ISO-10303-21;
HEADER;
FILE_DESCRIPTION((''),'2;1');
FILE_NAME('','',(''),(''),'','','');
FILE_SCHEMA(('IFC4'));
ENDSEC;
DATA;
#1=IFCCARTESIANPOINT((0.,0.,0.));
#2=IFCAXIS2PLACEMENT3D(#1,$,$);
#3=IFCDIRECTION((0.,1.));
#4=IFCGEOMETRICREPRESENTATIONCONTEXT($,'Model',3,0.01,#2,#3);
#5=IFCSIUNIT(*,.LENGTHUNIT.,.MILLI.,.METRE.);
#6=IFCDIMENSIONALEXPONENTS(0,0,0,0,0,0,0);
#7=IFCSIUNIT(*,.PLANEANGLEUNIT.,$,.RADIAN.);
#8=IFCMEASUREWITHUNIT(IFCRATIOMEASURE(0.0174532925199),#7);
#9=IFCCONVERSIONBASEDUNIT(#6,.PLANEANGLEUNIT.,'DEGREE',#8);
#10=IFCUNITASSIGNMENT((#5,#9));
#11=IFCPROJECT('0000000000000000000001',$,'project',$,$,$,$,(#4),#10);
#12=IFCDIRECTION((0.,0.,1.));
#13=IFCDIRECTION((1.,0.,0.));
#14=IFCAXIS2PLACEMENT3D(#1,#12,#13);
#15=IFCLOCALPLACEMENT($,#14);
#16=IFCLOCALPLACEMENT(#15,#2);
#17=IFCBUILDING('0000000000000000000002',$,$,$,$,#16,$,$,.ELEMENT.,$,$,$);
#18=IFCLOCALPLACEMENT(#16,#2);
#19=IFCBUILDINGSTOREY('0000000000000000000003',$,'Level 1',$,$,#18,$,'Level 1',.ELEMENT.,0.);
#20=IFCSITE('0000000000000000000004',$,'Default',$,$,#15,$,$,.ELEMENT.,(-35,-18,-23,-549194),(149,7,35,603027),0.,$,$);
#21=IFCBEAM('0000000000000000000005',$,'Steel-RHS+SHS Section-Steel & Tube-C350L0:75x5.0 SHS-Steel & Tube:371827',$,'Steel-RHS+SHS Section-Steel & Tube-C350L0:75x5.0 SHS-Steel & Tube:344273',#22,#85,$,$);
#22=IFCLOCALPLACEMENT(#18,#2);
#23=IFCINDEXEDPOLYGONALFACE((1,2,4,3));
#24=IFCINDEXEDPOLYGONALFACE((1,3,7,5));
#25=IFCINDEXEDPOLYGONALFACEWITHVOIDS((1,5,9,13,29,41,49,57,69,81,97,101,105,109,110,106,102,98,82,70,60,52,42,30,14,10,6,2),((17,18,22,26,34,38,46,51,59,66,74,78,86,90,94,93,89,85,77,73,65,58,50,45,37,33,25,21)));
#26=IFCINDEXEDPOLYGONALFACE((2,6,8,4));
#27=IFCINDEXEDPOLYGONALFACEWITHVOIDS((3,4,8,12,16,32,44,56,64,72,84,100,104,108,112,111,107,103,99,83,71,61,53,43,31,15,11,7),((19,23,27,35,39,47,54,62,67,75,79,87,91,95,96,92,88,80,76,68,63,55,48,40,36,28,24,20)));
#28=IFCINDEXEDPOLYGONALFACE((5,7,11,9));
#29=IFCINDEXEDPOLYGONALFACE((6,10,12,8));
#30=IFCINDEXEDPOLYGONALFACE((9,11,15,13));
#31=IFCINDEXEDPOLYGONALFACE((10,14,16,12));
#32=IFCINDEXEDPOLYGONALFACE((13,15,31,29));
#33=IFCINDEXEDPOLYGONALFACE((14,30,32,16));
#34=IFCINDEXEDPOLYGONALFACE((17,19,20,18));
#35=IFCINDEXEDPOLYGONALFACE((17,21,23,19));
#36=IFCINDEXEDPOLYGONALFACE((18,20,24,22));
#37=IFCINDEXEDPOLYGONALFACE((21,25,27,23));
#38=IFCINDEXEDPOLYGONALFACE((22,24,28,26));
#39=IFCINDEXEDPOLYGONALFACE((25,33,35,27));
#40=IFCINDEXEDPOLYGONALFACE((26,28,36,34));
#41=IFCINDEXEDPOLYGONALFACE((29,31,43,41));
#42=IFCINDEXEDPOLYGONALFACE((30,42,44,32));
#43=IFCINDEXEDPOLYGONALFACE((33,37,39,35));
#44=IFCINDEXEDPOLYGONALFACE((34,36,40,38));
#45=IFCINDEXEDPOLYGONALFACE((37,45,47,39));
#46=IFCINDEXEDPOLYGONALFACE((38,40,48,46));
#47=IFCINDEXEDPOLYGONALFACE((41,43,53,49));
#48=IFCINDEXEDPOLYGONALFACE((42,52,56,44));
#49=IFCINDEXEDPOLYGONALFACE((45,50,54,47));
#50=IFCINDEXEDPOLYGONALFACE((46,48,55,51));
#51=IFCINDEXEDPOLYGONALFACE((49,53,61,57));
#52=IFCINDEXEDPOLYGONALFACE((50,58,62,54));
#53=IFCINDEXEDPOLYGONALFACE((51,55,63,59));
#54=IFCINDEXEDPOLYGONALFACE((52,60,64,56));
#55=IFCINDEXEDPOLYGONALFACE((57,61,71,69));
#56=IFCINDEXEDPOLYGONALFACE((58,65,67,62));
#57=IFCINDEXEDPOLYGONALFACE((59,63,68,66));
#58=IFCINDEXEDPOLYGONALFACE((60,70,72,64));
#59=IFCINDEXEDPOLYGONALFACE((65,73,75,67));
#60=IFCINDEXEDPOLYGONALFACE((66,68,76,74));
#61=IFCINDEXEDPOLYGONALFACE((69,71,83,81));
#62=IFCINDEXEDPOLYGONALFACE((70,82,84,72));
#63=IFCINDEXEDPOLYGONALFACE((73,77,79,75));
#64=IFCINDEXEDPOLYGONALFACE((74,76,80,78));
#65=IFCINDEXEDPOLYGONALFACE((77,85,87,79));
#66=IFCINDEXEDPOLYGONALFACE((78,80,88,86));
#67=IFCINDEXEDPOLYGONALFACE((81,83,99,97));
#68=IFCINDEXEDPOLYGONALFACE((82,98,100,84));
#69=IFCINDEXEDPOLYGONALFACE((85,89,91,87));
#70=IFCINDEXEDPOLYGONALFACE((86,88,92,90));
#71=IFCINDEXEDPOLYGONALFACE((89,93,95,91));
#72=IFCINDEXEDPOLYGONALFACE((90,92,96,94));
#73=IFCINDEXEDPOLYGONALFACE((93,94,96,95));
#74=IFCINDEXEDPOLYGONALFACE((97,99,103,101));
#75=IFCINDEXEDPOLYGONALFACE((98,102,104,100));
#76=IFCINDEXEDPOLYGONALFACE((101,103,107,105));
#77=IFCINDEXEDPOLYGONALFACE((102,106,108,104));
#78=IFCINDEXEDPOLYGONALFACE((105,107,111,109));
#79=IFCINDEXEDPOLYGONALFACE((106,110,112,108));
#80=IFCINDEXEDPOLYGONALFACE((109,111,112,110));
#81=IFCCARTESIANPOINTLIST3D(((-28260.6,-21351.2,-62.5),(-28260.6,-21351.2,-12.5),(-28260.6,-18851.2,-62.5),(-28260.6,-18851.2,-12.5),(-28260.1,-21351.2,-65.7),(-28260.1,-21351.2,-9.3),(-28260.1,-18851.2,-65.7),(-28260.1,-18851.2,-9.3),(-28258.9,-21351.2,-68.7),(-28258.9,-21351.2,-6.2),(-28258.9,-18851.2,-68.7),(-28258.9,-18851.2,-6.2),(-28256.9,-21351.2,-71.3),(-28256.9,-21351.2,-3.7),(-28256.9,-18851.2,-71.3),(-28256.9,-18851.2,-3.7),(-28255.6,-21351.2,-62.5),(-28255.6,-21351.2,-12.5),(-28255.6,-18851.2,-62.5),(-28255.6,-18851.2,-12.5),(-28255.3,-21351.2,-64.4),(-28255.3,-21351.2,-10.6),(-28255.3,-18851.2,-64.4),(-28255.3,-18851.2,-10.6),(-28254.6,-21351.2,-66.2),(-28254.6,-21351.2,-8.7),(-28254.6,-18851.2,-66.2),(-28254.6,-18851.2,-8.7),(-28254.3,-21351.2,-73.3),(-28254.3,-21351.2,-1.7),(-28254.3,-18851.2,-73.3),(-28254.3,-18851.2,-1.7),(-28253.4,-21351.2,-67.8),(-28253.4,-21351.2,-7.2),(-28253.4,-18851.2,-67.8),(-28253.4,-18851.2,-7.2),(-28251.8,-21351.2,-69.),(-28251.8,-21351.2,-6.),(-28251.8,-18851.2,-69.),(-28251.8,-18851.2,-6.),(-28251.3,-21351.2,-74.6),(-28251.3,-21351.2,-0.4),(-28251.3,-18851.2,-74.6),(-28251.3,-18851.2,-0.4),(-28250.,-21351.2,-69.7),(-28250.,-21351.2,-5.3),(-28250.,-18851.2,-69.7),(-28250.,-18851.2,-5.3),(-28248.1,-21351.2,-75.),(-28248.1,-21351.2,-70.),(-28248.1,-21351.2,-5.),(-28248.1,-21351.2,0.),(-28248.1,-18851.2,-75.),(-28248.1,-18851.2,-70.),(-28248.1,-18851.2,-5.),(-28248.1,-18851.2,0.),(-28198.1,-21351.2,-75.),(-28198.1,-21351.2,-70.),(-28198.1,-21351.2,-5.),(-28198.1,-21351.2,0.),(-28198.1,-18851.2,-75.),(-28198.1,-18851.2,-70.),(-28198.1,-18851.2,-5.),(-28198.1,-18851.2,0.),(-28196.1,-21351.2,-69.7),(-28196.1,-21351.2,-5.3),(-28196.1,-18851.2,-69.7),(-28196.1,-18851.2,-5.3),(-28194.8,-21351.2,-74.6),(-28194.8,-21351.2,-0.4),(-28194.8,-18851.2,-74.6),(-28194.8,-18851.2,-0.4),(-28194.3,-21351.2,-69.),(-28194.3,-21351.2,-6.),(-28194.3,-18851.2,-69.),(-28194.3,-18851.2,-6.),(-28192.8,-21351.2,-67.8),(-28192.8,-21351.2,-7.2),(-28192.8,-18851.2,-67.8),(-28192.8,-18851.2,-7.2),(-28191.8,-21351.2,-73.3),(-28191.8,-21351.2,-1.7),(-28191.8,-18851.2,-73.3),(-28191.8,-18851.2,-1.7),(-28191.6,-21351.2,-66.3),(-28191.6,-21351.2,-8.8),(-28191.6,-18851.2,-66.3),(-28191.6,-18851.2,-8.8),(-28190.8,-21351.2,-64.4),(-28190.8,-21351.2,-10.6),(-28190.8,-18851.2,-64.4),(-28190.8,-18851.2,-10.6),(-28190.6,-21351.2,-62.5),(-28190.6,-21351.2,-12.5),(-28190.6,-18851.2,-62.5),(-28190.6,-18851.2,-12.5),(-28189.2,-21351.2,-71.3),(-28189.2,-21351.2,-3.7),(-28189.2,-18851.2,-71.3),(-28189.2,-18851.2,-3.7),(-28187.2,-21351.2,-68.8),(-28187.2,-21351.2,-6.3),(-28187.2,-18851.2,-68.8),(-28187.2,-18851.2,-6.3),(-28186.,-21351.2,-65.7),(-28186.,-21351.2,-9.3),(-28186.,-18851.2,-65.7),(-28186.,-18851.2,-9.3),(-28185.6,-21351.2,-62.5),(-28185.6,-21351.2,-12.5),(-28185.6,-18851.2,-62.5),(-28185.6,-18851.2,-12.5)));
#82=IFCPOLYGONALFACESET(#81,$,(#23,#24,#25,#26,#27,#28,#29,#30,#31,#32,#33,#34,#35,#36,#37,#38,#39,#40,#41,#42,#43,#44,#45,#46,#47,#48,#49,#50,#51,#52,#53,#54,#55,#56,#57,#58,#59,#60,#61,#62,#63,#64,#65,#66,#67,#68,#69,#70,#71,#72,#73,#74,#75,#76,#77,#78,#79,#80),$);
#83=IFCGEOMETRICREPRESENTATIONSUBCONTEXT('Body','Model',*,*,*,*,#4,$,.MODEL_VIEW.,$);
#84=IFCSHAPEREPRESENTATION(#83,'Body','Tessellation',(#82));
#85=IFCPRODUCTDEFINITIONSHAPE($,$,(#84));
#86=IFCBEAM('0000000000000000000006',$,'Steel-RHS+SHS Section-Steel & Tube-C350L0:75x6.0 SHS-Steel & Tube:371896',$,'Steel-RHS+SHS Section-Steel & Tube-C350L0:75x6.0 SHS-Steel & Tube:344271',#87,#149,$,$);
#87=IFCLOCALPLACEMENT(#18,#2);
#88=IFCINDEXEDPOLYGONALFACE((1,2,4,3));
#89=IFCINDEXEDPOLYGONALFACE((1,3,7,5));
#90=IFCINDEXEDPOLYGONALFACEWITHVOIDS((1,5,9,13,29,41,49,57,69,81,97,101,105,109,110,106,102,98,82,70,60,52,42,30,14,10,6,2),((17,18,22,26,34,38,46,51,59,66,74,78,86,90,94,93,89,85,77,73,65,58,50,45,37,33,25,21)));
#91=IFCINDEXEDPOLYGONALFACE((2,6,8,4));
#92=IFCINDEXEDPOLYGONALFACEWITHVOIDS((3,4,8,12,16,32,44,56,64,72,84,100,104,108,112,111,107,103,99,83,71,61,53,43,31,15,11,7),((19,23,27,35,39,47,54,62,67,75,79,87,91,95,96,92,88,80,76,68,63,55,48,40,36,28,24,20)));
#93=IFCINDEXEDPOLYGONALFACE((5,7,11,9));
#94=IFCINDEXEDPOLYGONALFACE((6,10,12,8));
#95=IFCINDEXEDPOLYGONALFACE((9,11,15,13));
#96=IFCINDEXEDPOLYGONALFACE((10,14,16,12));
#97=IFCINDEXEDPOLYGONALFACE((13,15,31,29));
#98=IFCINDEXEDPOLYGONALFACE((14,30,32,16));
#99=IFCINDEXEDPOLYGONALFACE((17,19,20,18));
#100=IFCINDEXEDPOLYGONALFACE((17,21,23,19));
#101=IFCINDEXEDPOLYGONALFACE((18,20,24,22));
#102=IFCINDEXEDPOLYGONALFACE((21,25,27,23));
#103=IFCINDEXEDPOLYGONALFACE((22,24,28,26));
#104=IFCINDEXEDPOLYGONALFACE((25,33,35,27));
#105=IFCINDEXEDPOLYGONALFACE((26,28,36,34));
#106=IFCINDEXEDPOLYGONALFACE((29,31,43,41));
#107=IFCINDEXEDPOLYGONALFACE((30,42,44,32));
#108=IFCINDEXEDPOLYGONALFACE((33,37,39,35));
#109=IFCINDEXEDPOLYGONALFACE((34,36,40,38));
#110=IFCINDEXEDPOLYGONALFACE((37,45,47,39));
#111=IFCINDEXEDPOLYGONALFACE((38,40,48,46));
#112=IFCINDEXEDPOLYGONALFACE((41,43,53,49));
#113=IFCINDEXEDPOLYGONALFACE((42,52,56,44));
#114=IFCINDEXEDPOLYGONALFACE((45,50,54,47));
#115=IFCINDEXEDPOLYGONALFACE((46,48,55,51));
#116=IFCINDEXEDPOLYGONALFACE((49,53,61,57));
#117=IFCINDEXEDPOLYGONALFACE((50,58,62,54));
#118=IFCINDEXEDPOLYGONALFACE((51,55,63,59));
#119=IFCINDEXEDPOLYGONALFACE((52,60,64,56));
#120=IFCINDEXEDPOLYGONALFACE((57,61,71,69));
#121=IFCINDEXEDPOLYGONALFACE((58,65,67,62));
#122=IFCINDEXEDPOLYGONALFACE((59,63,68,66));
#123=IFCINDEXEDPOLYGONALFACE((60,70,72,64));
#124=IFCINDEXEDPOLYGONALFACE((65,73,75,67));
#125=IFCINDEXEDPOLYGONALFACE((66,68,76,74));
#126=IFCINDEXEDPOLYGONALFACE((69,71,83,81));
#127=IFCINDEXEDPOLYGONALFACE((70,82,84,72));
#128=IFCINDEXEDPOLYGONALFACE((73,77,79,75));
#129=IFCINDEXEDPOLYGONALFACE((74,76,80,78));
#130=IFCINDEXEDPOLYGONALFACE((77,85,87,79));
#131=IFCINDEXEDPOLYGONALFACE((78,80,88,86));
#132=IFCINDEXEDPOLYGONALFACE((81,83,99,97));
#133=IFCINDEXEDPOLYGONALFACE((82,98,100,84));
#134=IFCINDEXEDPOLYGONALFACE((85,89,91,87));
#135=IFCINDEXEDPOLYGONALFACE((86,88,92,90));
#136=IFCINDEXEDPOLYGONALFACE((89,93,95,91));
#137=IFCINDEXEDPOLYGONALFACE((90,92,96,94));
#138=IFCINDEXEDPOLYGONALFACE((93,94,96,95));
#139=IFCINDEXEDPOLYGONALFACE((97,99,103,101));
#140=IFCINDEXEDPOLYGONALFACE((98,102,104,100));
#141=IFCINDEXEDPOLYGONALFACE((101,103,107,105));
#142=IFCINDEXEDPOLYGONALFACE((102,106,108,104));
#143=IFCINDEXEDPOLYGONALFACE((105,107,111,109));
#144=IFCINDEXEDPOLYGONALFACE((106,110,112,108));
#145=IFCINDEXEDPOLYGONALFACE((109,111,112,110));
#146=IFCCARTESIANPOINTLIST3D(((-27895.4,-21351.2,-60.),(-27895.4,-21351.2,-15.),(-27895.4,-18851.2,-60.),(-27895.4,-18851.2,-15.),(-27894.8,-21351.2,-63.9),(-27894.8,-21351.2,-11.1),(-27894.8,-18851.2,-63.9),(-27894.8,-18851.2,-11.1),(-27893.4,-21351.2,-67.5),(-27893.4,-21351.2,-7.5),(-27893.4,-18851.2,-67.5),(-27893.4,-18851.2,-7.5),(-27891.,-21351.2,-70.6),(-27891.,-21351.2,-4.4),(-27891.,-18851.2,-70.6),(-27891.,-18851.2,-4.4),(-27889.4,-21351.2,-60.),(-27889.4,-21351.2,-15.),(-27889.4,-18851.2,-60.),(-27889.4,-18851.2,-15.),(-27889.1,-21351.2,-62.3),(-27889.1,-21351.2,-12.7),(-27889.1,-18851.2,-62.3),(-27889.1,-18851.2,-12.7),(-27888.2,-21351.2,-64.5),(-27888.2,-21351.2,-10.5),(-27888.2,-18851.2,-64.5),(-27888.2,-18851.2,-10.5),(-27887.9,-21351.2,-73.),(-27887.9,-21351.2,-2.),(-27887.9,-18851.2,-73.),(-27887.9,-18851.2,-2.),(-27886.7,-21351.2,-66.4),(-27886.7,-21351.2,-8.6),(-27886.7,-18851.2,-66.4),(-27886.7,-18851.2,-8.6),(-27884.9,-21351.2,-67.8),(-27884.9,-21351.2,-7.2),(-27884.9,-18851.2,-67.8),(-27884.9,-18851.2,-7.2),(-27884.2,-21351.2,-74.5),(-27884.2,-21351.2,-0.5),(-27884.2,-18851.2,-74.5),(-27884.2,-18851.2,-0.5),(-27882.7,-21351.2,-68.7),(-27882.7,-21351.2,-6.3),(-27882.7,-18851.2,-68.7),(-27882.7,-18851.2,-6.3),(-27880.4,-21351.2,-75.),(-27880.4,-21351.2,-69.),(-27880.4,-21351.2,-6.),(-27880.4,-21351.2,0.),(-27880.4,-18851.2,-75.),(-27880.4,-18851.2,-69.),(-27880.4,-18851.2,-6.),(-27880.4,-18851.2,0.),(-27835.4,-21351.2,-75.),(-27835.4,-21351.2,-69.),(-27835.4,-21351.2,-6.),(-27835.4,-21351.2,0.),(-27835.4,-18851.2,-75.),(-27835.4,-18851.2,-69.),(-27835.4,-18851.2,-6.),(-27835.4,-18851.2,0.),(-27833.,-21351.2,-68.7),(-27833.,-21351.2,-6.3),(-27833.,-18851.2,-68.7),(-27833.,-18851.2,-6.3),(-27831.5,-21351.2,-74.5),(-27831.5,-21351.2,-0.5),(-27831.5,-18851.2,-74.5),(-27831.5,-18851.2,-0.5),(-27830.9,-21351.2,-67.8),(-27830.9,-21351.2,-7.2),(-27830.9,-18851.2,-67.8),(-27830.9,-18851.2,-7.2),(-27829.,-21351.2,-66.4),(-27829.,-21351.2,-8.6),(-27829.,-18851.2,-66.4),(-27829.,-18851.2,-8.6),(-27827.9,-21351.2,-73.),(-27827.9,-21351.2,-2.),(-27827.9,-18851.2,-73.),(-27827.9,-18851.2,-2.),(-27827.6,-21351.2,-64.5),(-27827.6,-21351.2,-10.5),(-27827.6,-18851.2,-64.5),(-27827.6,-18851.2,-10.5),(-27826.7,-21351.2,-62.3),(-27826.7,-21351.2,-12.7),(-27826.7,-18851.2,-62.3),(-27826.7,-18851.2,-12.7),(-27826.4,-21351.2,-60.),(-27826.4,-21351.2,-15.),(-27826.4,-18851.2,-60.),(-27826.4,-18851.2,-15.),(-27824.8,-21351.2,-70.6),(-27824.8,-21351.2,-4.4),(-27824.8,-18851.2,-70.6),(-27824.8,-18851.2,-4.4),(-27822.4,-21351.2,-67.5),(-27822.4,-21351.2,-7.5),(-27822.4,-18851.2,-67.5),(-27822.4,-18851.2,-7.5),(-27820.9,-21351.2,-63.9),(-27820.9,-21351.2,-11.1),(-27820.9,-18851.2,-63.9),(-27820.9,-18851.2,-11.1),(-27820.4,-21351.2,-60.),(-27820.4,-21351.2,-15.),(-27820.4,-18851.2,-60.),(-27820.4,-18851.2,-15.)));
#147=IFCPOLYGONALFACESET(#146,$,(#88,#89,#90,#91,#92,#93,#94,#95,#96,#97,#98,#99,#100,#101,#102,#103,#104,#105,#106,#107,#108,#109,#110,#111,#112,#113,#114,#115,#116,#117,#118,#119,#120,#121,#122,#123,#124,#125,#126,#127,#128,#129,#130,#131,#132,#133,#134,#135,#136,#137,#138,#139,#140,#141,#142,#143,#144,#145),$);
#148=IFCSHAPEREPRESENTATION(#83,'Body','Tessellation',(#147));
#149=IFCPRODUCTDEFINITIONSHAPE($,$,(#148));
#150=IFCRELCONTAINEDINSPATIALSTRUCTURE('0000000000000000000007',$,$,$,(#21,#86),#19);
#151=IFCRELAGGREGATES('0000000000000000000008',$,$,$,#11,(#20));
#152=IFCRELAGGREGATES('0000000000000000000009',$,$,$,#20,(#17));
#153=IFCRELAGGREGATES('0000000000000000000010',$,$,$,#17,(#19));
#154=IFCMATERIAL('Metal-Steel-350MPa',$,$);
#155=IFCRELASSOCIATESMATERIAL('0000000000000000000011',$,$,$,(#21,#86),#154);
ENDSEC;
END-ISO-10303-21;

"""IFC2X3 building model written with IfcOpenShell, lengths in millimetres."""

from ifc_helpers import new_model, entity, si_unit, converted_unit, direction, frame, frame_2d, origin, origin_with_axes, place, context, subcontext, project, spatial, polyline, circle_curve, parameter, trimmed, segment, composite_curve, outline, extrude, material, element, save


model = new_model("IFC2X3")

# Units and contexts
model_context = context("Model", 3, precision=0.01, world=origin(), true_north=direction((0.0, 1.0)))
body_context = subcontext(model_context, "Body", "Model", "MODEL_VIEW")
ifc_project = project(units=[si_unit("LENGTHUNIT", "METRE", prefix="MILLI"), converted_unit("PLANEANGLEUNIT", "DEGREE", entity("IfcRatioMeasure", 0.0174532925199), si_unit("PLANEANGLEUNIT", "RADIAN"), dimensions=[0, 0, 0, 0, 0, 0, 0])], contexts=[model_context])

# Site, building, storey
site_placement = place(None, origin_with_axes())
site = spatial("IfcSite", under=ifc_project, at=site_placement, Name="Default", CompositionType="ELEMENT", RefLatitude=(-35, -18, -23, -549194), RefLongitude=(149, 7, 35, 603027), RefElevation=0.0)
building_placement = place(site_placement, origin())
building = spatial("IfcBuilding", under=site, at=building_placement, CompositionType="ELEMENT")
storey_placement = place(building_placement, origin())
storey = spatial("IfcBuildingStorey", under=building, at=storey_placement, Name="Level 1", LongName="Level 1", CompositionType="ELEMENT", Elevation=0.0)

# Beams
ifc_material = material(Name="Metal-Steel-350MPa")
beam_1_placement = place(storey_placement, frame((-28223.1, -18851.2, 0.0), z_axis=(0.0, 0.0, 1.0), x_axis=(0.0, -1.0, 0.0)))
element("IfcBeam", 1, at=beam_1_placement, inside=storey, material=ifc_material, Name="Steel-RHS+SHS Section-Steel & Tube-C350L0:75x5.0 SHS-Steel & Tube:371827", ObjectType="Steel-RHS+SHS Section-Steel & Tube-C350L0:75x5.0 SHS-Steel & Tube:344273", context=body_context, shape_type="SweptSolid", body=[
    extrude(outline(composite_curve([segment(trimmed(circle_curve(frame_2d((-25.0, -25.0), x_axis=(1.0, 0.0)), 12.5), [parameter(180.0)], [parameter(270.0)], True, "PARAMETER"), True, "CONTINUOUS"), segment(polyline([(-25.0, -37.5), (25.0, -37.5)]), True, "CONTINUOUS"), segment(trimmed(circle_curve(frame_2d((25.0, -25.0), x_axis=(1.0, 0.0)), 12.5), [parameter(270.0)], [parameter(0.0)], True, "PARAMETER"), True, "CONTINUOUS"), segment(polyline([(37.5, -25.0), (37.5, 25.0)]), True, "CONTINUOUS"), segment(trimmed(circle_curve(frame_2d((25.0, 25.0), x_axis=(1.0, 0.0)), 12.5), [parameter(0.0)], [parameter(90.0)], True, "PARAMETER"), True, "CONTINUOUS"), segment(polyline([(25.0, 37.5), (-25.0, 37.5)]), True, "CONTINUOUS"), segment(trimmed(circle_curve(frame_2d((-25.0, 25.0), x_axis=(1.0, 0.0)), 12.5), [parameter(90.0)], [parameter(180.0)], True, "PARAMETER"), True, "CONTINUOUS"), segment(polyline([(-37.5, 25.0), (-37.5, -25.0)]), True, "CONTINUOUS")], self_intersect=False), holes=[composite_curve([segment(polyline([(25.0, -32.5), (-25.0, -32.5)]), True, "CONTINUOUS"), segment(trimmed(circle_curve(frame_2d((-25.0, -25.0), x_axis=(1.0, 0.0)), 7.5), [parameter(180.0)], [parameter(270.0)], True, "PARAMETER"), False, "CONTINUOUS"), segment(polyline([(-32.5, -25.0), (-32.5, 25.0)]), True, "CONTINUOUS"), segment(trimmed(circle_curve(frame_2d((-25.0, 25.0), x_axis=(1.0, 0.0)), 7.5), [parameter(90.0)], [parameter(180.0)], True, "PARAMETER"), False, "CONTINUOUS"), segment(polyline([(-25.0, 32.5), (25.0, 32.5)]), True, "CONTINUOUS"), segment(trimmed(circle_curve(frame_2d((25.0, 25.0), x_axis=(1.0, 0.0)), 7.5), [parameter(360.0)], [parameter(90.0)], True, "PARAMETER"), False, "CONTINUOUS"), segment(polyline([(32.5, 25.0), (32.5, -25.0)]), True, "CONTINUOUS"), segment(trimmed(circle_curve(frame_2d((25.0, -25.0), x_axis=(1.0, 0.0)), 7.5), [parameter(270.0)], [parameter(360.0)], True, "PARAMETER"), False, "CONTINUOUS")], self_intersect=False)]), frame((0.0, 0.0, -37.5), z_axis=(1.0, 0.0, 0.0), x_axis=(0.0, -1.0, 0.0)), (0.0, 0.0, 1.0), 2500.0),
])
beam_2_placement = place(storey_placement, frame((-27857.9, -18851.2, 0.0), z_axis=(0.0, 0.0, 1.0), x_axis=(0.0, -1.0, 0.0)))
element("IfcBeam", 2, at=beam_2_placement, inside=storey, material=ifc_material, Name="Steel-RHS+SHS Section-Steel & Tube-C350L0:75x6.0 SHS-Steel & Tube:371896", ObjectType="Steel-RHS+SHS Section-Steel & Tube-C350L0:75x6.0 SHS-Steel & Tube:344271", context=body_context, shape_type="SweptSolid", body=[
    extrude(outline(composite_curve([segment(trimmed(circle_curve(frame_2d((-22.5, -22.5), x_axis=(1.0, 0.0)), 15.0), [parameter(180.0)], [parameter(270.0)], True, "PARAMETER"), True, "CONTINUOUS"), segment(polyline([(-22.5, -37.5), (22.5, -37.5)]), True, "CONTINUOUS"), segment(trimmed(circle_curve(frame_2d((22.5, -22.5), x_axis=(1.0, 0.0)), 15.0), [parameter(270.0)], [parameter(0.0)], True, "PARAMETER"), True, "CONTINUOUS"), segment(polyline([(37.5, -22.5), (37.5, 22.5)]), True, "CONTINUOUS"), segment(trimmed(circle_curve(frame_2d((22.5, 22.5), x_axis=(1.0, 0.0)), 15.0), [parameter(0.0)], [parameter(90.0)], True, "PARAMETER"), True, "CONTINUOUS"), segment(polyline([(22.5, 37.5), (-22.5, 37.5)]), True, "CONTINUOUS"), segment(trimmed(circle_curve(frame_2d((-22.5, 22.5), x_axis=(1.0, 0.0)), 15.0), [parameter(90.0)], [parameter(180.0)], True, "PARAMETER"), True, "CONTINUOUS"), segment(polyline([(-37.5, 22.5), (-37.5, -22.5)]), True, "CONTINUOUS")], self_intersect=False), holes=[composite_curve([segment(polyline([(22.5, -31.5), (-22.5, -31.5)]), True, "CONTINUOUS"), segment(trimmed(circle_curve(frame_2d((-22.5, -22.5), x_axis=(1.0, 0.0)), 9.0), [parameter(180.0)], [parameter(270.0)], True, "PARAMETER"), False, "CONTINUOUS"), segment(polyline([(-31.5, -22.5), (-31.5, 22.5)]), True, "CONTINUOUS"), segment(trimmed(circle_curve(frame_2d((-22.5, 22.5), x_axis=(1.0, 0.0)), 9.0), [parameter(90.0)], [parameter(180.0)], True, "PARAMETER"), False, "CONTINUOUS"), segment(polyline([(-22.5, 31.5), (22.5, 31.5)]), True, "CONTINUOUS"), segment(trimmed(circle_curve(frame_2d((22.5, 22.5), x_axis=(1.0, 0.0)), 9.0), [parameter(360.0)], [parameter(90.0)], True, "PARAMETER"), False, "CONTINUOUS"), segment(polyline([(31.5, 22.5), (31.5, -22.5)]), True, "CONTINUOUS"), segment(trimmed(circle_curve(frame_2d((22.5, -22.5), x_axis=(1.0, 0.0)), 9.0), [parameter(270.0)], [parameter(0.0)], True, "PARAMETER"), False, "CONTINUOUS")], self_intersect=False)]), frame((0.0, 0.0, -37.5), z_axis=(1.0, 0.0, 0.0), x_axis=(0.0, -1.0, 0.0)), (0.0, 0.0, 1.0), 2500.0),
])

save(model, "model.ifc")
